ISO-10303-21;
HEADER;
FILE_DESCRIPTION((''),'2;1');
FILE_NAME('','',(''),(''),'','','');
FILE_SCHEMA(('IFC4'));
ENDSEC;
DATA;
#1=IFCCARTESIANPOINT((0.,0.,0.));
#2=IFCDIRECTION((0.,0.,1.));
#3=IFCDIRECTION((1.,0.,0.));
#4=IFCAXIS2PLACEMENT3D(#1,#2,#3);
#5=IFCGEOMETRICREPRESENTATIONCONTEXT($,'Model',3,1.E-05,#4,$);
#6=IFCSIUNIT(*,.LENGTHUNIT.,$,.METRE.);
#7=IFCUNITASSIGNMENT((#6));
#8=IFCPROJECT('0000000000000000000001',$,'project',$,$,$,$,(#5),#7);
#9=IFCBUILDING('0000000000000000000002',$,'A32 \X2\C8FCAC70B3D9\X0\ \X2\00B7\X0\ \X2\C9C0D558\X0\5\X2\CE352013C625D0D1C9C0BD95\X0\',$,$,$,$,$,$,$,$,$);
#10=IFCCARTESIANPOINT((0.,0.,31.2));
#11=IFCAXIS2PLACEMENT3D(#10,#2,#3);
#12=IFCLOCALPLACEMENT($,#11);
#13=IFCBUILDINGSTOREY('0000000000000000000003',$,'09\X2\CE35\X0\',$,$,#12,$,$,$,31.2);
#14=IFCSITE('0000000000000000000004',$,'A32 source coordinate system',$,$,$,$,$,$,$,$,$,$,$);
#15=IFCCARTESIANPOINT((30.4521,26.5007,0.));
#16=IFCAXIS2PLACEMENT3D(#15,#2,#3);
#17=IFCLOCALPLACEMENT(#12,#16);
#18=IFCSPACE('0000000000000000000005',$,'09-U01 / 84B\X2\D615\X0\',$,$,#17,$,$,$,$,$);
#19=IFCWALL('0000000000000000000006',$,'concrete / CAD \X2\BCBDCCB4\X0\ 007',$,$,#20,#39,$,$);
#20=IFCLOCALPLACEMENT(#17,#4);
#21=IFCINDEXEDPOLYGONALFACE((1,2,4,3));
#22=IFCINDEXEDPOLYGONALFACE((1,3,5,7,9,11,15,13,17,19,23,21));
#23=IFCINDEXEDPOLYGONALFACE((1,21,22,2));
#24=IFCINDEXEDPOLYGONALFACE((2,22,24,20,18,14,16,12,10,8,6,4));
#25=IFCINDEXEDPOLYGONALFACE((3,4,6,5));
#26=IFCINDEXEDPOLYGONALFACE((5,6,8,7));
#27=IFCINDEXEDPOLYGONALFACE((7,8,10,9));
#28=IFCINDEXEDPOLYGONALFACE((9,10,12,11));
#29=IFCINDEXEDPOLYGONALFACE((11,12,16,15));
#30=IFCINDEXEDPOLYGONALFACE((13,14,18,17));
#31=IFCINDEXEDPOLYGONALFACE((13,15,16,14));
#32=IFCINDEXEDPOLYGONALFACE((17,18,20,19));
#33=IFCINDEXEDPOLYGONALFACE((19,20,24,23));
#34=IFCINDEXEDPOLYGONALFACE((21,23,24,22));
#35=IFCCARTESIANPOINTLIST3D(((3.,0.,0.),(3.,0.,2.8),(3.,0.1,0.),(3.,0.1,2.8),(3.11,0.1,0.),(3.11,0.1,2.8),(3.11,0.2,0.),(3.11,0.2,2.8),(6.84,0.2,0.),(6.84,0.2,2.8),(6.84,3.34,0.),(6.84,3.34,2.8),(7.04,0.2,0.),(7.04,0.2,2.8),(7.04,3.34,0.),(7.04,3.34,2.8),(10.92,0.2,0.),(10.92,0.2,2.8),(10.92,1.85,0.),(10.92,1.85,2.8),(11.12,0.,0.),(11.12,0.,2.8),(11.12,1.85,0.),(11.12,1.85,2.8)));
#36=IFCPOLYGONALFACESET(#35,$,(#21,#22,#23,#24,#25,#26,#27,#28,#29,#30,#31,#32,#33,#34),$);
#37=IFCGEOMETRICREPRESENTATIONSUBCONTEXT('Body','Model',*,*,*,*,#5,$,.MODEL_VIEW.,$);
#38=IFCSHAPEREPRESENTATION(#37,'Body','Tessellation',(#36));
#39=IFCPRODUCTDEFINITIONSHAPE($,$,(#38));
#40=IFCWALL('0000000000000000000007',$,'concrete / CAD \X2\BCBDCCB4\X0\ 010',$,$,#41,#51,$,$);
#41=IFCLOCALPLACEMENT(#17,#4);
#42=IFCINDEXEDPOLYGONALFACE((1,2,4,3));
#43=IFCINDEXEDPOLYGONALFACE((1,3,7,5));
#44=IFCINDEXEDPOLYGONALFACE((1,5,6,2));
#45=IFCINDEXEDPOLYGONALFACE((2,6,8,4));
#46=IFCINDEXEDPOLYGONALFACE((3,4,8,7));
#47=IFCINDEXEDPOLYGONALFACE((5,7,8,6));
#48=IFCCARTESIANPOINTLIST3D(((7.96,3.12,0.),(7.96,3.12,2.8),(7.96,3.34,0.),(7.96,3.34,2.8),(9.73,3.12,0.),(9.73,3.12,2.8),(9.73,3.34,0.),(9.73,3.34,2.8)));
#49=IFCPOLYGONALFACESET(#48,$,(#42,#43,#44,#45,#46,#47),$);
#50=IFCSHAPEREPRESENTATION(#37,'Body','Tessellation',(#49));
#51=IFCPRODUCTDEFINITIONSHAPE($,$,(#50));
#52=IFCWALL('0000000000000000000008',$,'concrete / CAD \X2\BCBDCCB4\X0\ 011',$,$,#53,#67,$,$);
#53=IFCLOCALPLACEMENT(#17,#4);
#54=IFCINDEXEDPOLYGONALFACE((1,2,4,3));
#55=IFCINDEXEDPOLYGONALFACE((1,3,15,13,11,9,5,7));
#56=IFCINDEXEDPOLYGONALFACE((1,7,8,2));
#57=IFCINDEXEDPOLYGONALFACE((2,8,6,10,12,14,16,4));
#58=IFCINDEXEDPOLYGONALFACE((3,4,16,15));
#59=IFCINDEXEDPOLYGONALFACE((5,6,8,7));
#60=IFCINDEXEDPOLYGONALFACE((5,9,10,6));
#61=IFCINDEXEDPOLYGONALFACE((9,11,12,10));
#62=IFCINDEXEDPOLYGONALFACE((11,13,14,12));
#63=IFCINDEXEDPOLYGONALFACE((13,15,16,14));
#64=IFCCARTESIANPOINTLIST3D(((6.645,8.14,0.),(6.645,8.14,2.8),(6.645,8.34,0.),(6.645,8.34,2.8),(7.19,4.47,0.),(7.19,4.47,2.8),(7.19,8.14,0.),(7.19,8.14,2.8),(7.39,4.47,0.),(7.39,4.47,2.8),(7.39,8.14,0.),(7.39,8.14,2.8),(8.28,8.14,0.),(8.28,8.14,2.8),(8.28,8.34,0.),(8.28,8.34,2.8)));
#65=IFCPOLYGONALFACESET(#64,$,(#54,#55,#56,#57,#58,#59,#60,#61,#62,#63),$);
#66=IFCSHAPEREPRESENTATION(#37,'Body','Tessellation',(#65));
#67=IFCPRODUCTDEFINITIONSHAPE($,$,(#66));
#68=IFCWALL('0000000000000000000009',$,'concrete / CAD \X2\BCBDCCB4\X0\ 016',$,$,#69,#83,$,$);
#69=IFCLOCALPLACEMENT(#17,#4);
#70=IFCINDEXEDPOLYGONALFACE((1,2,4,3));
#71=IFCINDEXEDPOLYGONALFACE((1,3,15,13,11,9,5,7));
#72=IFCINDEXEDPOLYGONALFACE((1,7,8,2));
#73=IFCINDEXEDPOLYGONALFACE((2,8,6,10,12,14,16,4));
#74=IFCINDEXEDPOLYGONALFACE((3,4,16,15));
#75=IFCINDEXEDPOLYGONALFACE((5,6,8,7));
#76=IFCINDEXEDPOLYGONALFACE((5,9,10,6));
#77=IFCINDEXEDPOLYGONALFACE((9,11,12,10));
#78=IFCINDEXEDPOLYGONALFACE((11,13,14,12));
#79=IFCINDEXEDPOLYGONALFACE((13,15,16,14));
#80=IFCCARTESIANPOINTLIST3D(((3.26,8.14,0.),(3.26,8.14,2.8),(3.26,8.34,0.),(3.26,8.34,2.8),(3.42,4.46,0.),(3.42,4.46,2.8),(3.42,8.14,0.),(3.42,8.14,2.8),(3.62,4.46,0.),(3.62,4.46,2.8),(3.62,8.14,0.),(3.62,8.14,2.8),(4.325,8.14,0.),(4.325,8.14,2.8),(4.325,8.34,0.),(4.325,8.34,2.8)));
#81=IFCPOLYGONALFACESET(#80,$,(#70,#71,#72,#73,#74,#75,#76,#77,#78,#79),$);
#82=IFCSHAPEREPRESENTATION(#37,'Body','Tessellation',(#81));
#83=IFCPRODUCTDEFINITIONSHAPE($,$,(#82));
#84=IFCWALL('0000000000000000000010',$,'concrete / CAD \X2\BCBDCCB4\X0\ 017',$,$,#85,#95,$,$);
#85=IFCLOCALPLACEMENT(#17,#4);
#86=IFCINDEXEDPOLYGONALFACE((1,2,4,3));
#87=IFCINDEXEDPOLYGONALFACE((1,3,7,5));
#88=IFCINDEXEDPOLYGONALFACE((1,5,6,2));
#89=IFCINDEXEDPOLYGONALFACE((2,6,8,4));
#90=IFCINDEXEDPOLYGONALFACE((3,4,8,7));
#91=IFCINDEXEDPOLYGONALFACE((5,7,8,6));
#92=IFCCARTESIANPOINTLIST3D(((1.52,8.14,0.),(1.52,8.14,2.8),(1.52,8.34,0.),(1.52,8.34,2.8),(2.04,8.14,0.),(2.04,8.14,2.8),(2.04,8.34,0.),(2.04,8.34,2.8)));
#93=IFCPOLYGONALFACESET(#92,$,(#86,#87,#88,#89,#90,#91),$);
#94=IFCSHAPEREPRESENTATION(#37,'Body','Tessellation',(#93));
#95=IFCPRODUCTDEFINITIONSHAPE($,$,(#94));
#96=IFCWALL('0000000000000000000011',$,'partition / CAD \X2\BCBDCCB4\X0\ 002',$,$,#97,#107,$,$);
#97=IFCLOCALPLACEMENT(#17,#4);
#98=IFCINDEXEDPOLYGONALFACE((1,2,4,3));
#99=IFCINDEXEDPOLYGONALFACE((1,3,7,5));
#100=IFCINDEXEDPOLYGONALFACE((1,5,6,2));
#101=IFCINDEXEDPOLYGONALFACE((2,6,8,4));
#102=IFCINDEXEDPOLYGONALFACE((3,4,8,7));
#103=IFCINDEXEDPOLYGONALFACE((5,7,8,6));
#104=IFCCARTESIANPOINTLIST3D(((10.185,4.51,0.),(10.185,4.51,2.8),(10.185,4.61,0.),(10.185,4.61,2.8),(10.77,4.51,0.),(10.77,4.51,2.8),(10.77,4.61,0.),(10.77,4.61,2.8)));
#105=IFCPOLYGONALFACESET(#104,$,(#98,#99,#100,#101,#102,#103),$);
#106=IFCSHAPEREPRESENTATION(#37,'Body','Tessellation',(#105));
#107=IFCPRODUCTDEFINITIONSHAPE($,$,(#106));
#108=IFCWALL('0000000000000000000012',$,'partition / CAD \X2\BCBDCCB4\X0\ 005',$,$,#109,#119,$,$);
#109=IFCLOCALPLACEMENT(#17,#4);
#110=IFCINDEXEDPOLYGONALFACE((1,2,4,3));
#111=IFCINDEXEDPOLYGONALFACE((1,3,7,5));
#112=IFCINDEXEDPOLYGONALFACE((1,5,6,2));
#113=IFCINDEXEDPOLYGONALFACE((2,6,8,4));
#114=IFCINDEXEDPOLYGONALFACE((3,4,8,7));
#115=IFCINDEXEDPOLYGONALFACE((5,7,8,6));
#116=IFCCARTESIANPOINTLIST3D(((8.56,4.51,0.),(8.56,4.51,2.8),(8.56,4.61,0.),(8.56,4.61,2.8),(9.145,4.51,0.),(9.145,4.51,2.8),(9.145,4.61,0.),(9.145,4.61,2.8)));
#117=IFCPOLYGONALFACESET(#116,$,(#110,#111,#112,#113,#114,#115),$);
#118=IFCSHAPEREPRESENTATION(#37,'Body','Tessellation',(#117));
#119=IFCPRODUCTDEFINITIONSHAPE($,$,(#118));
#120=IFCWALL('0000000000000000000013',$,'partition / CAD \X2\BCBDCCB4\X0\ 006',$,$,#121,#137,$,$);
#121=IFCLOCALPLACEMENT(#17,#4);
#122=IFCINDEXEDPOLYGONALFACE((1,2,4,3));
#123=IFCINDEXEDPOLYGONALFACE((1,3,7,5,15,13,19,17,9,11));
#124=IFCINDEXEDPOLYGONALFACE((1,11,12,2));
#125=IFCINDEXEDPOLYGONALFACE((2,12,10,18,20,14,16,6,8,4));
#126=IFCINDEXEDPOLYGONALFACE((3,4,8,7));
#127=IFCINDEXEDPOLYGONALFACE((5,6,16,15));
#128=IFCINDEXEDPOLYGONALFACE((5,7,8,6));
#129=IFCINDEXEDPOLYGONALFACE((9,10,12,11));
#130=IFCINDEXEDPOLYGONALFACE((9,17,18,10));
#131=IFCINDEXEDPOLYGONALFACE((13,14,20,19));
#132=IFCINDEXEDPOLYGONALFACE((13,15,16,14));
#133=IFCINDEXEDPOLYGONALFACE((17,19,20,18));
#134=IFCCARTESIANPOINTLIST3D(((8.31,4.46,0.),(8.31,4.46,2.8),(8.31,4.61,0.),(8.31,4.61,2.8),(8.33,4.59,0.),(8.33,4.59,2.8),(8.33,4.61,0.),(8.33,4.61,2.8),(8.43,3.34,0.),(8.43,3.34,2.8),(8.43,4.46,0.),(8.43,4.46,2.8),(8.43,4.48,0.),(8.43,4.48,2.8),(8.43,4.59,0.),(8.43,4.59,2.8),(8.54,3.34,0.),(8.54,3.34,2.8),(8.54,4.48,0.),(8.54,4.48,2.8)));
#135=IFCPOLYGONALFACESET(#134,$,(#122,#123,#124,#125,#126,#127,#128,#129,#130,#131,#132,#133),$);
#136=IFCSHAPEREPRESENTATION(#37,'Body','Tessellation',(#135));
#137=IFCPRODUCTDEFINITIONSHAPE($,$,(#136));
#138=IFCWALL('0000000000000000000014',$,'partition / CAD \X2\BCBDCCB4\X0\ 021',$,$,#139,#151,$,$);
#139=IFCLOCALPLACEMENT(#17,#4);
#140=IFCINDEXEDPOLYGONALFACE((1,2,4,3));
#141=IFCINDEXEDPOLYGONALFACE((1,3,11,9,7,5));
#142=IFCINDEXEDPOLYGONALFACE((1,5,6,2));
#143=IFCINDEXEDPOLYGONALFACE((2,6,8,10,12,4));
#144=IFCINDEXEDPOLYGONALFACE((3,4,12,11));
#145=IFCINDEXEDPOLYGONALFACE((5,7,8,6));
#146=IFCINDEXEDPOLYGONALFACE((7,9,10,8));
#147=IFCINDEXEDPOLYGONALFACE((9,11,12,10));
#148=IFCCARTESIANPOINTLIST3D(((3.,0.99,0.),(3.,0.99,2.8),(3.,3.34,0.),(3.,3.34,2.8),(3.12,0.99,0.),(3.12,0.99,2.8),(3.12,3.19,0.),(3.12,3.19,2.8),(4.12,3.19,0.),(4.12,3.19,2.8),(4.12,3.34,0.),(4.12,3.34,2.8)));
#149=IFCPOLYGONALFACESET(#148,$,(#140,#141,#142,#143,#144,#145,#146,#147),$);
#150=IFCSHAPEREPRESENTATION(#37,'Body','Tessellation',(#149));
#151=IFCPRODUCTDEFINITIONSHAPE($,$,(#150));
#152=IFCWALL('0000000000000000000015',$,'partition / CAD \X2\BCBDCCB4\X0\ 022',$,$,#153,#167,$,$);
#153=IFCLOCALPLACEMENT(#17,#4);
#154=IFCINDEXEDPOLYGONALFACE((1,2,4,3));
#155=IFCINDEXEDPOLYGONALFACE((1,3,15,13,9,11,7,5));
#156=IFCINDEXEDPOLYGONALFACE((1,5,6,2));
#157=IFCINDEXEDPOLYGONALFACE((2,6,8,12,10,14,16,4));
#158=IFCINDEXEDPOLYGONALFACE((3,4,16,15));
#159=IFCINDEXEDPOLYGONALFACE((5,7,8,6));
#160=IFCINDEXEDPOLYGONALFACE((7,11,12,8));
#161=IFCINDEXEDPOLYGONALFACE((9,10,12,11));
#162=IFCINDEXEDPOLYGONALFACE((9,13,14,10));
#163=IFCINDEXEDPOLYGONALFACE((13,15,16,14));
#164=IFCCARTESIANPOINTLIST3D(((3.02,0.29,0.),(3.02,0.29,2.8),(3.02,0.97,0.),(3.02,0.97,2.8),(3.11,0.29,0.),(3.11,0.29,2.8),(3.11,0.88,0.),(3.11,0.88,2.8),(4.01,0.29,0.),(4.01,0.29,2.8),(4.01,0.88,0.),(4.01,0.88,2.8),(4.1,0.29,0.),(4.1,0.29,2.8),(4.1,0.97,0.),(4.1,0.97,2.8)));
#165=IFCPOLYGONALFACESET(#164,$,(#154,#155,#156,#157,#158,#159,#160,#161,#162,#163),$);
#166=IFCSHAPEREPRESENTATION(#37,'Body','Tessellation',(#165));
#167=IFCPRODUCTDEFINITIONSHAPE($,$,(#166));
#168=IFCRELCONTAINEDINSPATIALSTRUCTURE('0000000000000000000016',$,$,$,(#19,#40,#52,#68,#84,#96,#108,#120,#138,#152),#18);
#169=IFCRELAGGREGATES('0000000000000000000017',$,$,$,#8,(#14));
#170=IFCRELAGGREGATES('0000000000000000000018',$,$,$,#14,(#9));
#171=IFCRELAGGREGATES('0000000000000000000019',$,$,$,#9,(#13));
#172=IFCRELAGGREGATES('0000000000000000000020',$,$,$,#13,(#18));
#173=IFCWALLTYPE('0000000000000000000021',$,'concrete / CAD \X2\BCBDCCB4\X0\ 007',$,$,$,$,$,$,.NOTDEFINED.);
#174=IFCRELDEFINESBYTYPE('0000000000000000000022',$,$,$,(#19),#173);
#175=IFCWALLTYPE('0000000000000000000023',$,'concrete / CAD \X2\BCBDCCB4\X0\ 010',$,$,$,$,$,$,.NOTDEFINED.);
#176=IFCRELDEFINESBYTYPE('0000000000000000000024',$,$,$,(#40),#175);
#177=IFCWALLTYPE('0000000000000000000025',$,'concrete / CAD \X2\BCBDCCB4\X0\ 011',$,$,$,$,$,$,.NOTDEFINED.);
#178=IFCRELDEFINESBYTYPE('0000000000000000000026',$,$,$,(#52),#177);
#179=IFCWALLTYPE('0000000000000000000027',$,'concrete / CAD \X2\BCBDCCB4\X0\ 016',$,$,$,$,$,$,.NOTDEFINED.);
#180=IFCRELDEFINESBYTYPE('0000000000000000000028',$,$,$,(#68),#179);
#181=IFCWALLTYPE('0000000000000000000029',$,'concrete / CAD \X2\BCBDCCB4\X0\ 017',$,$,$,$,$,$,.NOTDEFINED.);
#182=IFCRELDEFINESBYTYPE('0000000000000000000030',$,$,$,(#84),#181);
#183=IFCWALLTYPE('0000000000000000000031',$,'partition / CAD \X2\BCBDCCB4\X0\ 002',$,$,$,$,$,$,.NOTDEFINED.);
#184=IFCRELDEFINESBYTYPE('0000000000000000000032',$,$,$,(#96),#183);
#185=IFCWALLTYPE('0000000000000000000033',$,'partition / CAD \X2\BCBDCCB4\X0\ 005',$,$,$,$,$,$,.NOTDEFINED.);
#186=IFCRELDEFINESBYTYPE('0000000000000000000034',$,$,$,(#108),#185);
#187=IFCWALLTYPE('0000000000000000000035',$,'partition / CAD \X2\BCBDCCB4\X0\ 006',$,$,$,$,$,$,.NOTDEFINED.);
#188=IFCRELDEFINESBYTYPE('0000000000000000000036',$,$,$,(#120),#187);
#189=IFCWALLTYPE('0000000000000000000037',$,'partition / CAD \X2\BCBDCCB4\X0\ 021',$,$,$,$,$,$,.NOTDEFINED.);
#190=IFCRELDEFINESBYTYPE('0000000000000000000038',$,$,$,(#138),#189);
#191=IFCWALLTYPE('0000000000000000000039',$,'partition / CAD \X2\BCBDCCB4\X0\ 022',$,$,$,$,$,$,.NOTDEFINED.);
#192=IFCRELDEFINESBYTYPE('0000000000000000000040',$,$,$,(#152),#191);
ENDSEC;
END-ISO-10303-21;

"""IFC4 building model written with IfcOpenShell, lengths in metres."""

from ifc_helpers import new_model, si_unit, frame, origin, origin_with_axes, place, context, subcontext, project, spatial, polyline, outline, extrude, source, transform, mapped, type_object, type_shapes, element, save


model = new_model("IFC4")

# Units and contexts
model_context = context("Model", 3, precision=1e-05, world=origin_with_axes())
body_context = subcontext(model_context, "Body", "Model", "MODEL_VIEW")
ifc_project = project(units=[si_unit("LENGTHUNIT", "METRE")], contexts=[model_context])

# Site, building, storey, space
site = spatial("IfcSite", under=ifc_project, Name="A32 source coordinate system")
building = spatial("IfcBuilding", under=site, Name="A32 주거동 · 지하5층–옥탑지붕")
storey_placement = place(None, frame((0.0, 0.0, 31.2), z_axis=(0.0, 0.0, 1.0), x_axis=(1.0, 0.0, 0.0)))
storey = spatial("IfcBuildingStorey", under=building, at=storey_placement, Name="09층", Elevation=31.2)
space_1_placement = place(storey_placement, frame((30.4521, 26.5007, 0.0), z_axis=(0.0, 0.0, 1.0), x_axis=(1.0, 0.0, 0.0)))
space_1 = spatial("IfcSpace", under=storey, at=space_1_placement, Name="09-U01 / 84B형")

# Walls
wall_type_1 = type_object("IfcWallType", Name="concrete / CAD 벽체 007", PredefinedType="NOTDEFINED")
shared_shape_1 = source(origin(), body_context, "Body", "SweptSolid", [
    extrude(outline(polyline([(3.0, 0.0), (3.0, 0.1), (3.11, 0.1), (3.11, 0.2), (6.84, 0.2), (6.84, 3.34), (7.04, 3.34), (7.04, 0.2), (10.92, 0.2), (10.92, 1.85), (11.12, 1.85), (11.12, 0.0), (3.0, 0.0)])), origin(), (0.0, 0.0, 1.0), 2.8),
])
type_shapes(wall_type_1, [shared_shape_1])
wall_1_placement = place(space_1_placement, origin_with_axes())
element("IfcWall", 1, at=wall_1_placement, inside=space_1, type_object=wall_type_1, Name="concrete / CAD 벽체 007", context=body_context, shape_type="MappedRepresentation", body=[
    mapped(shared_shape_1, transform((0.0, 0.0, 0.0), scale=1.0)),
])
wall_type_2 = type_object("IfcWallType", Name="concrete / CAD 벽체 010", PredefinedType="NOTDEFINED")
shared_shape_2 = source(origin(), body_context, "Body", "SweptSolid", [
    extrude(outline(polyline([(7.96, 3.12), (7.96, 3.34), (9.73, 3.34), (9.73, 3.12), (7.96, 3.12)])), origin(), (0.0, 0.0, 1.0), 2.8),
])
type_shapes(wall_type_2, [shared_shape_2])
wall_2_placement = place(space_1_placement, origin_with_axes())
element("IfcWall", 2, at=wall_2_placement, inside=space_1, type_object=wall_type_2, Name="concrete / CAD 벽체 010", context=body_context, shape_type="MappedRepresentation", body=[
    mapped(shared_shape_2, transform((0.0, 0.0, 0.0), scale=1.0)),
])
wall_type_3 = type_object("IfcWallType", Name="concrete / CAD 벽체 011", PredefinedType="NOTDEFINED")
shared_shape_3 = source(origin(), body_context, "Body", "SweptSolid", [
    extrude(outline(polyline([(7.19, 8.14), (6.645, 8.14), (6.645, 8.34), (8.28, 8.34), (8.28, 8.14), (7.39, 8.14), (7.39, 4.47), (7.19, 4.47), (7.19, 8.14)])), origin(), (0.0, 0.0, 1.0), 2.8),
])
type_shapes(wall_type_3, [shared_shape_3])
wall_3_placement = place(space_1_placement, origin_with_axes())
element("IfcWall", 3, at=wall_3_placement, inside=space_1, type_object=wall_type_3, Name="concrete / CAD 벽체 011", context=body_context, shape_type="MappedRepresentation", body=[
    mapped(shared_shape_3, transform((0.0, 0.0, 0.0), scale=1.0)),
])
wall_type_4 = type_object("IfcWallType", Name="concrete / CAD 벽체 016", PredefinedType="NOTDEFINED")
shared_shape_4 = source(origin(), body_context, "Body", "SweptSolid", [
    extrude(outline(polyline([(3.26, 8.14), (3.26, 8.34), (4.325, 8.34), (4.325, 8.14), (3.62, 8.14), (3.62, 4.46), (3.42, 4.46), (3.42, 8.14), (3.26, 8.14)])), origin(), (0.0, 0.0, 1.0), 2.8),
])
type_shapes(wall_type_4, [shared_shape_4])
wall_4_placement = place(space_1_placement, origin_with_axes())
element("IfcWall", 4, at=wall_4_placement, inside=space_1, type_object=wall_type_4, Name="concrete / CAD 벽체 016", context=body_context, shape_type="MappedRepresentation", body=[
    mapped(shared_shape_4, transform((0.0, 0.0, 0.0), scale=1.0)),
])
wall_type_5 = type_object("IfcWallType", Name="concrete / CAD 벽체 017", PredefinedType="NOTDEFINED")
shared_shape_5 = source(origin(), body_context, "Body", "SweptSolid", [
    extrude(outline(polyline([(1.52, 8.34), (2.04, 8.34), (2.04, 8.14), (1.52, 8.14), (1.52, 8.34)])), origin(), (0.0, 0.0, 1.0), 2.8),
])
type_shapes(wall_type_5, [shared_shape_5])
wall_5_placement = place(space_1_placement, origin_with_axes())
element("IfcWall", 5, at=wall_5_placement, inside=space_1, type_object=wall_type_5, Name="concrete / CAD 벽체 017", context=body_context, shape_type="MappedRepresentation", body=[
    mapped(shared_shape_5, transform((0.0, 0.0, 0.0), scale=1.0)),
])
wall_type_6 = type_object("IfcWallType", Name="partition / CAD 벽체 002", PredefinedType="NOTDEFINED")
shared_shape_6 = source(origin(), body_context, "Body", "SweptSolid", [
    extrude(outline(polyline([(10.185, 4.51), (10.185, 4.61), (10.77, 4.61), (10.77, 4.51), (10.185, 4.51)])), origin(), (0.0, 0.0, 1.0), 2.8),
])
type_shapes(wall_type_6, [shared_shape_6])
wall_6_placement = place(space_1_placement, origin_with_axes())
element("IfcWall", 6, at=wall_6_placement, inside=space_1, type_object=wall_type_6, Name="partition / CAD 벽체 002", context=body_context, shape_type="MappedRepresentation", body=[
    mapped(shared_shape_6, transform((0.0, 0.0, 0.0), scale=1.0)),
])
wall_type_7 = type_object("IfcWallType", Name="partition / CAD 벽체 005", PredefinedType="NOTDEFINED")
shared_shape_7 = source(origin(), body_context, "Body", "SweptSolid", [
    extrude(outline(polyline([(8.56, 4.51), (8.56, 4.61), (9.145, 4.61), (9.145, 4.51), (8.56, 4.51)])), origin(), (0.0, 0.0, 1.0), 2.8),
])
type_shapes(wall_type_7, [shared_shape_7])
wall_7_placement = place(space_1_placement, origin_with_axes())
element("IfcWall", 7, at=wall_7_placement, inside=space_1, type_object=wall_type_7, Name="partition / CAD 벽체 005", context=body_context, shape_type="MappedRepresentation", body=[
    mapped(shared_shape_7, transform((0.0, 0.0, 0.0), scale=1.0)),
])
wall_type_8 = type_object("IfcWallType", Name="partition / CAD 벽체 006", PredefinedType="NOTDEFINED")
shared_shape_8 = source(origin(), body_context, "Body", "SweptSolid", [
    extrude(outline(polyline([(8.43, 4.46), (8.31, 4.46), (8.31, 4.61), (8.33, 4.61), (8.33, 4.59), (8.43, 4.59), (8.43, 4.48), (8.54, 4.48), (8.54, 3.34), (8.43, 3.34), (8.43, 4.46)])), origin(), (0.0, 0.0, 1.0), 2.8),
])
type_shapes(wall_type_8, [shared_shape_8])
wall_8_placement = place(space_1_placement, origin_with_axes())
element("IfcWall", 8, at=wall_8_placement, inside=space_1, type_object=wall_type_8, Name="partition / CAD 벽체 006", context=body_context, shape_type="MappedRepresentation", body=[
    mapped(shared_shape_8, transform((0.0, 0.0, 0.0), scale=1.0)),
])
wall_type_9 = type_object("IfcWallType", Name="partition / CAD 벽체 021", PredefinedType="NOTDEFINED")
shared_shape_9 = source(origin(), body_context, "Body", "SweptSolid", [
    extrude(outline(polyline([(4.12, 3.34), (4.12, 3.19), (3.12, 3.19), (3.12, 0.99), (3.0, 0.99), (3.0, 3.34), (4.12, 3.34)])), origin(), (0.0, 0.0, 1.0), 2.8),
])
type_shapes(wall_type_9, [shared_shape_9])
wall_9_placement = place(space_1_placement, origin_with_axes())
element("IfcWall", 9, at=wall_9_placement, inside=space_1, type_object=wall_type_9, Name="partition / CAD 벽체 021", context=body_context, shape_type="MappedRepresentation", body=[
    mapped(shared_shape_9, transform((0.0, 0.0, 0.0), scale=1.0)),
])
wall_type_10 = type_object("IfcWallType", Name="partition / CAD 벽체 022", PredefinedType="NOTDEFINED")
shared_shape_10 = source(origin(), body_context, "Body", "SweptSolid", [
    extrude(outline(polyline([(4.1, 0.97), (4.1, 0.29), (4.01, 0.29), (4.01, 0.88), (3.11, 0.88), (3.11, 0.29), (3.02, 0.29), (3.02, 0.97), (4.1, 0.97)])), origin(), (0.0, 0.0, 1.0), 2.8),
])
type_shapes(wall_type_10, [shared_shape_10])
wall_10_placement = place(space_1_placement, origin_with_axes())
element("IfcWall", 10, at=wall_10_placement, inside=space_1, type_object=wall_type_10, Name="partition / CAD 벽체 022", context=body_context, shape_type="MappedRepresentation", body=[
    mapped(shared_shape_10, transform((0.0, 0.0, 0.0), scale=1.0)),
])

save(model, "model.ifc")
